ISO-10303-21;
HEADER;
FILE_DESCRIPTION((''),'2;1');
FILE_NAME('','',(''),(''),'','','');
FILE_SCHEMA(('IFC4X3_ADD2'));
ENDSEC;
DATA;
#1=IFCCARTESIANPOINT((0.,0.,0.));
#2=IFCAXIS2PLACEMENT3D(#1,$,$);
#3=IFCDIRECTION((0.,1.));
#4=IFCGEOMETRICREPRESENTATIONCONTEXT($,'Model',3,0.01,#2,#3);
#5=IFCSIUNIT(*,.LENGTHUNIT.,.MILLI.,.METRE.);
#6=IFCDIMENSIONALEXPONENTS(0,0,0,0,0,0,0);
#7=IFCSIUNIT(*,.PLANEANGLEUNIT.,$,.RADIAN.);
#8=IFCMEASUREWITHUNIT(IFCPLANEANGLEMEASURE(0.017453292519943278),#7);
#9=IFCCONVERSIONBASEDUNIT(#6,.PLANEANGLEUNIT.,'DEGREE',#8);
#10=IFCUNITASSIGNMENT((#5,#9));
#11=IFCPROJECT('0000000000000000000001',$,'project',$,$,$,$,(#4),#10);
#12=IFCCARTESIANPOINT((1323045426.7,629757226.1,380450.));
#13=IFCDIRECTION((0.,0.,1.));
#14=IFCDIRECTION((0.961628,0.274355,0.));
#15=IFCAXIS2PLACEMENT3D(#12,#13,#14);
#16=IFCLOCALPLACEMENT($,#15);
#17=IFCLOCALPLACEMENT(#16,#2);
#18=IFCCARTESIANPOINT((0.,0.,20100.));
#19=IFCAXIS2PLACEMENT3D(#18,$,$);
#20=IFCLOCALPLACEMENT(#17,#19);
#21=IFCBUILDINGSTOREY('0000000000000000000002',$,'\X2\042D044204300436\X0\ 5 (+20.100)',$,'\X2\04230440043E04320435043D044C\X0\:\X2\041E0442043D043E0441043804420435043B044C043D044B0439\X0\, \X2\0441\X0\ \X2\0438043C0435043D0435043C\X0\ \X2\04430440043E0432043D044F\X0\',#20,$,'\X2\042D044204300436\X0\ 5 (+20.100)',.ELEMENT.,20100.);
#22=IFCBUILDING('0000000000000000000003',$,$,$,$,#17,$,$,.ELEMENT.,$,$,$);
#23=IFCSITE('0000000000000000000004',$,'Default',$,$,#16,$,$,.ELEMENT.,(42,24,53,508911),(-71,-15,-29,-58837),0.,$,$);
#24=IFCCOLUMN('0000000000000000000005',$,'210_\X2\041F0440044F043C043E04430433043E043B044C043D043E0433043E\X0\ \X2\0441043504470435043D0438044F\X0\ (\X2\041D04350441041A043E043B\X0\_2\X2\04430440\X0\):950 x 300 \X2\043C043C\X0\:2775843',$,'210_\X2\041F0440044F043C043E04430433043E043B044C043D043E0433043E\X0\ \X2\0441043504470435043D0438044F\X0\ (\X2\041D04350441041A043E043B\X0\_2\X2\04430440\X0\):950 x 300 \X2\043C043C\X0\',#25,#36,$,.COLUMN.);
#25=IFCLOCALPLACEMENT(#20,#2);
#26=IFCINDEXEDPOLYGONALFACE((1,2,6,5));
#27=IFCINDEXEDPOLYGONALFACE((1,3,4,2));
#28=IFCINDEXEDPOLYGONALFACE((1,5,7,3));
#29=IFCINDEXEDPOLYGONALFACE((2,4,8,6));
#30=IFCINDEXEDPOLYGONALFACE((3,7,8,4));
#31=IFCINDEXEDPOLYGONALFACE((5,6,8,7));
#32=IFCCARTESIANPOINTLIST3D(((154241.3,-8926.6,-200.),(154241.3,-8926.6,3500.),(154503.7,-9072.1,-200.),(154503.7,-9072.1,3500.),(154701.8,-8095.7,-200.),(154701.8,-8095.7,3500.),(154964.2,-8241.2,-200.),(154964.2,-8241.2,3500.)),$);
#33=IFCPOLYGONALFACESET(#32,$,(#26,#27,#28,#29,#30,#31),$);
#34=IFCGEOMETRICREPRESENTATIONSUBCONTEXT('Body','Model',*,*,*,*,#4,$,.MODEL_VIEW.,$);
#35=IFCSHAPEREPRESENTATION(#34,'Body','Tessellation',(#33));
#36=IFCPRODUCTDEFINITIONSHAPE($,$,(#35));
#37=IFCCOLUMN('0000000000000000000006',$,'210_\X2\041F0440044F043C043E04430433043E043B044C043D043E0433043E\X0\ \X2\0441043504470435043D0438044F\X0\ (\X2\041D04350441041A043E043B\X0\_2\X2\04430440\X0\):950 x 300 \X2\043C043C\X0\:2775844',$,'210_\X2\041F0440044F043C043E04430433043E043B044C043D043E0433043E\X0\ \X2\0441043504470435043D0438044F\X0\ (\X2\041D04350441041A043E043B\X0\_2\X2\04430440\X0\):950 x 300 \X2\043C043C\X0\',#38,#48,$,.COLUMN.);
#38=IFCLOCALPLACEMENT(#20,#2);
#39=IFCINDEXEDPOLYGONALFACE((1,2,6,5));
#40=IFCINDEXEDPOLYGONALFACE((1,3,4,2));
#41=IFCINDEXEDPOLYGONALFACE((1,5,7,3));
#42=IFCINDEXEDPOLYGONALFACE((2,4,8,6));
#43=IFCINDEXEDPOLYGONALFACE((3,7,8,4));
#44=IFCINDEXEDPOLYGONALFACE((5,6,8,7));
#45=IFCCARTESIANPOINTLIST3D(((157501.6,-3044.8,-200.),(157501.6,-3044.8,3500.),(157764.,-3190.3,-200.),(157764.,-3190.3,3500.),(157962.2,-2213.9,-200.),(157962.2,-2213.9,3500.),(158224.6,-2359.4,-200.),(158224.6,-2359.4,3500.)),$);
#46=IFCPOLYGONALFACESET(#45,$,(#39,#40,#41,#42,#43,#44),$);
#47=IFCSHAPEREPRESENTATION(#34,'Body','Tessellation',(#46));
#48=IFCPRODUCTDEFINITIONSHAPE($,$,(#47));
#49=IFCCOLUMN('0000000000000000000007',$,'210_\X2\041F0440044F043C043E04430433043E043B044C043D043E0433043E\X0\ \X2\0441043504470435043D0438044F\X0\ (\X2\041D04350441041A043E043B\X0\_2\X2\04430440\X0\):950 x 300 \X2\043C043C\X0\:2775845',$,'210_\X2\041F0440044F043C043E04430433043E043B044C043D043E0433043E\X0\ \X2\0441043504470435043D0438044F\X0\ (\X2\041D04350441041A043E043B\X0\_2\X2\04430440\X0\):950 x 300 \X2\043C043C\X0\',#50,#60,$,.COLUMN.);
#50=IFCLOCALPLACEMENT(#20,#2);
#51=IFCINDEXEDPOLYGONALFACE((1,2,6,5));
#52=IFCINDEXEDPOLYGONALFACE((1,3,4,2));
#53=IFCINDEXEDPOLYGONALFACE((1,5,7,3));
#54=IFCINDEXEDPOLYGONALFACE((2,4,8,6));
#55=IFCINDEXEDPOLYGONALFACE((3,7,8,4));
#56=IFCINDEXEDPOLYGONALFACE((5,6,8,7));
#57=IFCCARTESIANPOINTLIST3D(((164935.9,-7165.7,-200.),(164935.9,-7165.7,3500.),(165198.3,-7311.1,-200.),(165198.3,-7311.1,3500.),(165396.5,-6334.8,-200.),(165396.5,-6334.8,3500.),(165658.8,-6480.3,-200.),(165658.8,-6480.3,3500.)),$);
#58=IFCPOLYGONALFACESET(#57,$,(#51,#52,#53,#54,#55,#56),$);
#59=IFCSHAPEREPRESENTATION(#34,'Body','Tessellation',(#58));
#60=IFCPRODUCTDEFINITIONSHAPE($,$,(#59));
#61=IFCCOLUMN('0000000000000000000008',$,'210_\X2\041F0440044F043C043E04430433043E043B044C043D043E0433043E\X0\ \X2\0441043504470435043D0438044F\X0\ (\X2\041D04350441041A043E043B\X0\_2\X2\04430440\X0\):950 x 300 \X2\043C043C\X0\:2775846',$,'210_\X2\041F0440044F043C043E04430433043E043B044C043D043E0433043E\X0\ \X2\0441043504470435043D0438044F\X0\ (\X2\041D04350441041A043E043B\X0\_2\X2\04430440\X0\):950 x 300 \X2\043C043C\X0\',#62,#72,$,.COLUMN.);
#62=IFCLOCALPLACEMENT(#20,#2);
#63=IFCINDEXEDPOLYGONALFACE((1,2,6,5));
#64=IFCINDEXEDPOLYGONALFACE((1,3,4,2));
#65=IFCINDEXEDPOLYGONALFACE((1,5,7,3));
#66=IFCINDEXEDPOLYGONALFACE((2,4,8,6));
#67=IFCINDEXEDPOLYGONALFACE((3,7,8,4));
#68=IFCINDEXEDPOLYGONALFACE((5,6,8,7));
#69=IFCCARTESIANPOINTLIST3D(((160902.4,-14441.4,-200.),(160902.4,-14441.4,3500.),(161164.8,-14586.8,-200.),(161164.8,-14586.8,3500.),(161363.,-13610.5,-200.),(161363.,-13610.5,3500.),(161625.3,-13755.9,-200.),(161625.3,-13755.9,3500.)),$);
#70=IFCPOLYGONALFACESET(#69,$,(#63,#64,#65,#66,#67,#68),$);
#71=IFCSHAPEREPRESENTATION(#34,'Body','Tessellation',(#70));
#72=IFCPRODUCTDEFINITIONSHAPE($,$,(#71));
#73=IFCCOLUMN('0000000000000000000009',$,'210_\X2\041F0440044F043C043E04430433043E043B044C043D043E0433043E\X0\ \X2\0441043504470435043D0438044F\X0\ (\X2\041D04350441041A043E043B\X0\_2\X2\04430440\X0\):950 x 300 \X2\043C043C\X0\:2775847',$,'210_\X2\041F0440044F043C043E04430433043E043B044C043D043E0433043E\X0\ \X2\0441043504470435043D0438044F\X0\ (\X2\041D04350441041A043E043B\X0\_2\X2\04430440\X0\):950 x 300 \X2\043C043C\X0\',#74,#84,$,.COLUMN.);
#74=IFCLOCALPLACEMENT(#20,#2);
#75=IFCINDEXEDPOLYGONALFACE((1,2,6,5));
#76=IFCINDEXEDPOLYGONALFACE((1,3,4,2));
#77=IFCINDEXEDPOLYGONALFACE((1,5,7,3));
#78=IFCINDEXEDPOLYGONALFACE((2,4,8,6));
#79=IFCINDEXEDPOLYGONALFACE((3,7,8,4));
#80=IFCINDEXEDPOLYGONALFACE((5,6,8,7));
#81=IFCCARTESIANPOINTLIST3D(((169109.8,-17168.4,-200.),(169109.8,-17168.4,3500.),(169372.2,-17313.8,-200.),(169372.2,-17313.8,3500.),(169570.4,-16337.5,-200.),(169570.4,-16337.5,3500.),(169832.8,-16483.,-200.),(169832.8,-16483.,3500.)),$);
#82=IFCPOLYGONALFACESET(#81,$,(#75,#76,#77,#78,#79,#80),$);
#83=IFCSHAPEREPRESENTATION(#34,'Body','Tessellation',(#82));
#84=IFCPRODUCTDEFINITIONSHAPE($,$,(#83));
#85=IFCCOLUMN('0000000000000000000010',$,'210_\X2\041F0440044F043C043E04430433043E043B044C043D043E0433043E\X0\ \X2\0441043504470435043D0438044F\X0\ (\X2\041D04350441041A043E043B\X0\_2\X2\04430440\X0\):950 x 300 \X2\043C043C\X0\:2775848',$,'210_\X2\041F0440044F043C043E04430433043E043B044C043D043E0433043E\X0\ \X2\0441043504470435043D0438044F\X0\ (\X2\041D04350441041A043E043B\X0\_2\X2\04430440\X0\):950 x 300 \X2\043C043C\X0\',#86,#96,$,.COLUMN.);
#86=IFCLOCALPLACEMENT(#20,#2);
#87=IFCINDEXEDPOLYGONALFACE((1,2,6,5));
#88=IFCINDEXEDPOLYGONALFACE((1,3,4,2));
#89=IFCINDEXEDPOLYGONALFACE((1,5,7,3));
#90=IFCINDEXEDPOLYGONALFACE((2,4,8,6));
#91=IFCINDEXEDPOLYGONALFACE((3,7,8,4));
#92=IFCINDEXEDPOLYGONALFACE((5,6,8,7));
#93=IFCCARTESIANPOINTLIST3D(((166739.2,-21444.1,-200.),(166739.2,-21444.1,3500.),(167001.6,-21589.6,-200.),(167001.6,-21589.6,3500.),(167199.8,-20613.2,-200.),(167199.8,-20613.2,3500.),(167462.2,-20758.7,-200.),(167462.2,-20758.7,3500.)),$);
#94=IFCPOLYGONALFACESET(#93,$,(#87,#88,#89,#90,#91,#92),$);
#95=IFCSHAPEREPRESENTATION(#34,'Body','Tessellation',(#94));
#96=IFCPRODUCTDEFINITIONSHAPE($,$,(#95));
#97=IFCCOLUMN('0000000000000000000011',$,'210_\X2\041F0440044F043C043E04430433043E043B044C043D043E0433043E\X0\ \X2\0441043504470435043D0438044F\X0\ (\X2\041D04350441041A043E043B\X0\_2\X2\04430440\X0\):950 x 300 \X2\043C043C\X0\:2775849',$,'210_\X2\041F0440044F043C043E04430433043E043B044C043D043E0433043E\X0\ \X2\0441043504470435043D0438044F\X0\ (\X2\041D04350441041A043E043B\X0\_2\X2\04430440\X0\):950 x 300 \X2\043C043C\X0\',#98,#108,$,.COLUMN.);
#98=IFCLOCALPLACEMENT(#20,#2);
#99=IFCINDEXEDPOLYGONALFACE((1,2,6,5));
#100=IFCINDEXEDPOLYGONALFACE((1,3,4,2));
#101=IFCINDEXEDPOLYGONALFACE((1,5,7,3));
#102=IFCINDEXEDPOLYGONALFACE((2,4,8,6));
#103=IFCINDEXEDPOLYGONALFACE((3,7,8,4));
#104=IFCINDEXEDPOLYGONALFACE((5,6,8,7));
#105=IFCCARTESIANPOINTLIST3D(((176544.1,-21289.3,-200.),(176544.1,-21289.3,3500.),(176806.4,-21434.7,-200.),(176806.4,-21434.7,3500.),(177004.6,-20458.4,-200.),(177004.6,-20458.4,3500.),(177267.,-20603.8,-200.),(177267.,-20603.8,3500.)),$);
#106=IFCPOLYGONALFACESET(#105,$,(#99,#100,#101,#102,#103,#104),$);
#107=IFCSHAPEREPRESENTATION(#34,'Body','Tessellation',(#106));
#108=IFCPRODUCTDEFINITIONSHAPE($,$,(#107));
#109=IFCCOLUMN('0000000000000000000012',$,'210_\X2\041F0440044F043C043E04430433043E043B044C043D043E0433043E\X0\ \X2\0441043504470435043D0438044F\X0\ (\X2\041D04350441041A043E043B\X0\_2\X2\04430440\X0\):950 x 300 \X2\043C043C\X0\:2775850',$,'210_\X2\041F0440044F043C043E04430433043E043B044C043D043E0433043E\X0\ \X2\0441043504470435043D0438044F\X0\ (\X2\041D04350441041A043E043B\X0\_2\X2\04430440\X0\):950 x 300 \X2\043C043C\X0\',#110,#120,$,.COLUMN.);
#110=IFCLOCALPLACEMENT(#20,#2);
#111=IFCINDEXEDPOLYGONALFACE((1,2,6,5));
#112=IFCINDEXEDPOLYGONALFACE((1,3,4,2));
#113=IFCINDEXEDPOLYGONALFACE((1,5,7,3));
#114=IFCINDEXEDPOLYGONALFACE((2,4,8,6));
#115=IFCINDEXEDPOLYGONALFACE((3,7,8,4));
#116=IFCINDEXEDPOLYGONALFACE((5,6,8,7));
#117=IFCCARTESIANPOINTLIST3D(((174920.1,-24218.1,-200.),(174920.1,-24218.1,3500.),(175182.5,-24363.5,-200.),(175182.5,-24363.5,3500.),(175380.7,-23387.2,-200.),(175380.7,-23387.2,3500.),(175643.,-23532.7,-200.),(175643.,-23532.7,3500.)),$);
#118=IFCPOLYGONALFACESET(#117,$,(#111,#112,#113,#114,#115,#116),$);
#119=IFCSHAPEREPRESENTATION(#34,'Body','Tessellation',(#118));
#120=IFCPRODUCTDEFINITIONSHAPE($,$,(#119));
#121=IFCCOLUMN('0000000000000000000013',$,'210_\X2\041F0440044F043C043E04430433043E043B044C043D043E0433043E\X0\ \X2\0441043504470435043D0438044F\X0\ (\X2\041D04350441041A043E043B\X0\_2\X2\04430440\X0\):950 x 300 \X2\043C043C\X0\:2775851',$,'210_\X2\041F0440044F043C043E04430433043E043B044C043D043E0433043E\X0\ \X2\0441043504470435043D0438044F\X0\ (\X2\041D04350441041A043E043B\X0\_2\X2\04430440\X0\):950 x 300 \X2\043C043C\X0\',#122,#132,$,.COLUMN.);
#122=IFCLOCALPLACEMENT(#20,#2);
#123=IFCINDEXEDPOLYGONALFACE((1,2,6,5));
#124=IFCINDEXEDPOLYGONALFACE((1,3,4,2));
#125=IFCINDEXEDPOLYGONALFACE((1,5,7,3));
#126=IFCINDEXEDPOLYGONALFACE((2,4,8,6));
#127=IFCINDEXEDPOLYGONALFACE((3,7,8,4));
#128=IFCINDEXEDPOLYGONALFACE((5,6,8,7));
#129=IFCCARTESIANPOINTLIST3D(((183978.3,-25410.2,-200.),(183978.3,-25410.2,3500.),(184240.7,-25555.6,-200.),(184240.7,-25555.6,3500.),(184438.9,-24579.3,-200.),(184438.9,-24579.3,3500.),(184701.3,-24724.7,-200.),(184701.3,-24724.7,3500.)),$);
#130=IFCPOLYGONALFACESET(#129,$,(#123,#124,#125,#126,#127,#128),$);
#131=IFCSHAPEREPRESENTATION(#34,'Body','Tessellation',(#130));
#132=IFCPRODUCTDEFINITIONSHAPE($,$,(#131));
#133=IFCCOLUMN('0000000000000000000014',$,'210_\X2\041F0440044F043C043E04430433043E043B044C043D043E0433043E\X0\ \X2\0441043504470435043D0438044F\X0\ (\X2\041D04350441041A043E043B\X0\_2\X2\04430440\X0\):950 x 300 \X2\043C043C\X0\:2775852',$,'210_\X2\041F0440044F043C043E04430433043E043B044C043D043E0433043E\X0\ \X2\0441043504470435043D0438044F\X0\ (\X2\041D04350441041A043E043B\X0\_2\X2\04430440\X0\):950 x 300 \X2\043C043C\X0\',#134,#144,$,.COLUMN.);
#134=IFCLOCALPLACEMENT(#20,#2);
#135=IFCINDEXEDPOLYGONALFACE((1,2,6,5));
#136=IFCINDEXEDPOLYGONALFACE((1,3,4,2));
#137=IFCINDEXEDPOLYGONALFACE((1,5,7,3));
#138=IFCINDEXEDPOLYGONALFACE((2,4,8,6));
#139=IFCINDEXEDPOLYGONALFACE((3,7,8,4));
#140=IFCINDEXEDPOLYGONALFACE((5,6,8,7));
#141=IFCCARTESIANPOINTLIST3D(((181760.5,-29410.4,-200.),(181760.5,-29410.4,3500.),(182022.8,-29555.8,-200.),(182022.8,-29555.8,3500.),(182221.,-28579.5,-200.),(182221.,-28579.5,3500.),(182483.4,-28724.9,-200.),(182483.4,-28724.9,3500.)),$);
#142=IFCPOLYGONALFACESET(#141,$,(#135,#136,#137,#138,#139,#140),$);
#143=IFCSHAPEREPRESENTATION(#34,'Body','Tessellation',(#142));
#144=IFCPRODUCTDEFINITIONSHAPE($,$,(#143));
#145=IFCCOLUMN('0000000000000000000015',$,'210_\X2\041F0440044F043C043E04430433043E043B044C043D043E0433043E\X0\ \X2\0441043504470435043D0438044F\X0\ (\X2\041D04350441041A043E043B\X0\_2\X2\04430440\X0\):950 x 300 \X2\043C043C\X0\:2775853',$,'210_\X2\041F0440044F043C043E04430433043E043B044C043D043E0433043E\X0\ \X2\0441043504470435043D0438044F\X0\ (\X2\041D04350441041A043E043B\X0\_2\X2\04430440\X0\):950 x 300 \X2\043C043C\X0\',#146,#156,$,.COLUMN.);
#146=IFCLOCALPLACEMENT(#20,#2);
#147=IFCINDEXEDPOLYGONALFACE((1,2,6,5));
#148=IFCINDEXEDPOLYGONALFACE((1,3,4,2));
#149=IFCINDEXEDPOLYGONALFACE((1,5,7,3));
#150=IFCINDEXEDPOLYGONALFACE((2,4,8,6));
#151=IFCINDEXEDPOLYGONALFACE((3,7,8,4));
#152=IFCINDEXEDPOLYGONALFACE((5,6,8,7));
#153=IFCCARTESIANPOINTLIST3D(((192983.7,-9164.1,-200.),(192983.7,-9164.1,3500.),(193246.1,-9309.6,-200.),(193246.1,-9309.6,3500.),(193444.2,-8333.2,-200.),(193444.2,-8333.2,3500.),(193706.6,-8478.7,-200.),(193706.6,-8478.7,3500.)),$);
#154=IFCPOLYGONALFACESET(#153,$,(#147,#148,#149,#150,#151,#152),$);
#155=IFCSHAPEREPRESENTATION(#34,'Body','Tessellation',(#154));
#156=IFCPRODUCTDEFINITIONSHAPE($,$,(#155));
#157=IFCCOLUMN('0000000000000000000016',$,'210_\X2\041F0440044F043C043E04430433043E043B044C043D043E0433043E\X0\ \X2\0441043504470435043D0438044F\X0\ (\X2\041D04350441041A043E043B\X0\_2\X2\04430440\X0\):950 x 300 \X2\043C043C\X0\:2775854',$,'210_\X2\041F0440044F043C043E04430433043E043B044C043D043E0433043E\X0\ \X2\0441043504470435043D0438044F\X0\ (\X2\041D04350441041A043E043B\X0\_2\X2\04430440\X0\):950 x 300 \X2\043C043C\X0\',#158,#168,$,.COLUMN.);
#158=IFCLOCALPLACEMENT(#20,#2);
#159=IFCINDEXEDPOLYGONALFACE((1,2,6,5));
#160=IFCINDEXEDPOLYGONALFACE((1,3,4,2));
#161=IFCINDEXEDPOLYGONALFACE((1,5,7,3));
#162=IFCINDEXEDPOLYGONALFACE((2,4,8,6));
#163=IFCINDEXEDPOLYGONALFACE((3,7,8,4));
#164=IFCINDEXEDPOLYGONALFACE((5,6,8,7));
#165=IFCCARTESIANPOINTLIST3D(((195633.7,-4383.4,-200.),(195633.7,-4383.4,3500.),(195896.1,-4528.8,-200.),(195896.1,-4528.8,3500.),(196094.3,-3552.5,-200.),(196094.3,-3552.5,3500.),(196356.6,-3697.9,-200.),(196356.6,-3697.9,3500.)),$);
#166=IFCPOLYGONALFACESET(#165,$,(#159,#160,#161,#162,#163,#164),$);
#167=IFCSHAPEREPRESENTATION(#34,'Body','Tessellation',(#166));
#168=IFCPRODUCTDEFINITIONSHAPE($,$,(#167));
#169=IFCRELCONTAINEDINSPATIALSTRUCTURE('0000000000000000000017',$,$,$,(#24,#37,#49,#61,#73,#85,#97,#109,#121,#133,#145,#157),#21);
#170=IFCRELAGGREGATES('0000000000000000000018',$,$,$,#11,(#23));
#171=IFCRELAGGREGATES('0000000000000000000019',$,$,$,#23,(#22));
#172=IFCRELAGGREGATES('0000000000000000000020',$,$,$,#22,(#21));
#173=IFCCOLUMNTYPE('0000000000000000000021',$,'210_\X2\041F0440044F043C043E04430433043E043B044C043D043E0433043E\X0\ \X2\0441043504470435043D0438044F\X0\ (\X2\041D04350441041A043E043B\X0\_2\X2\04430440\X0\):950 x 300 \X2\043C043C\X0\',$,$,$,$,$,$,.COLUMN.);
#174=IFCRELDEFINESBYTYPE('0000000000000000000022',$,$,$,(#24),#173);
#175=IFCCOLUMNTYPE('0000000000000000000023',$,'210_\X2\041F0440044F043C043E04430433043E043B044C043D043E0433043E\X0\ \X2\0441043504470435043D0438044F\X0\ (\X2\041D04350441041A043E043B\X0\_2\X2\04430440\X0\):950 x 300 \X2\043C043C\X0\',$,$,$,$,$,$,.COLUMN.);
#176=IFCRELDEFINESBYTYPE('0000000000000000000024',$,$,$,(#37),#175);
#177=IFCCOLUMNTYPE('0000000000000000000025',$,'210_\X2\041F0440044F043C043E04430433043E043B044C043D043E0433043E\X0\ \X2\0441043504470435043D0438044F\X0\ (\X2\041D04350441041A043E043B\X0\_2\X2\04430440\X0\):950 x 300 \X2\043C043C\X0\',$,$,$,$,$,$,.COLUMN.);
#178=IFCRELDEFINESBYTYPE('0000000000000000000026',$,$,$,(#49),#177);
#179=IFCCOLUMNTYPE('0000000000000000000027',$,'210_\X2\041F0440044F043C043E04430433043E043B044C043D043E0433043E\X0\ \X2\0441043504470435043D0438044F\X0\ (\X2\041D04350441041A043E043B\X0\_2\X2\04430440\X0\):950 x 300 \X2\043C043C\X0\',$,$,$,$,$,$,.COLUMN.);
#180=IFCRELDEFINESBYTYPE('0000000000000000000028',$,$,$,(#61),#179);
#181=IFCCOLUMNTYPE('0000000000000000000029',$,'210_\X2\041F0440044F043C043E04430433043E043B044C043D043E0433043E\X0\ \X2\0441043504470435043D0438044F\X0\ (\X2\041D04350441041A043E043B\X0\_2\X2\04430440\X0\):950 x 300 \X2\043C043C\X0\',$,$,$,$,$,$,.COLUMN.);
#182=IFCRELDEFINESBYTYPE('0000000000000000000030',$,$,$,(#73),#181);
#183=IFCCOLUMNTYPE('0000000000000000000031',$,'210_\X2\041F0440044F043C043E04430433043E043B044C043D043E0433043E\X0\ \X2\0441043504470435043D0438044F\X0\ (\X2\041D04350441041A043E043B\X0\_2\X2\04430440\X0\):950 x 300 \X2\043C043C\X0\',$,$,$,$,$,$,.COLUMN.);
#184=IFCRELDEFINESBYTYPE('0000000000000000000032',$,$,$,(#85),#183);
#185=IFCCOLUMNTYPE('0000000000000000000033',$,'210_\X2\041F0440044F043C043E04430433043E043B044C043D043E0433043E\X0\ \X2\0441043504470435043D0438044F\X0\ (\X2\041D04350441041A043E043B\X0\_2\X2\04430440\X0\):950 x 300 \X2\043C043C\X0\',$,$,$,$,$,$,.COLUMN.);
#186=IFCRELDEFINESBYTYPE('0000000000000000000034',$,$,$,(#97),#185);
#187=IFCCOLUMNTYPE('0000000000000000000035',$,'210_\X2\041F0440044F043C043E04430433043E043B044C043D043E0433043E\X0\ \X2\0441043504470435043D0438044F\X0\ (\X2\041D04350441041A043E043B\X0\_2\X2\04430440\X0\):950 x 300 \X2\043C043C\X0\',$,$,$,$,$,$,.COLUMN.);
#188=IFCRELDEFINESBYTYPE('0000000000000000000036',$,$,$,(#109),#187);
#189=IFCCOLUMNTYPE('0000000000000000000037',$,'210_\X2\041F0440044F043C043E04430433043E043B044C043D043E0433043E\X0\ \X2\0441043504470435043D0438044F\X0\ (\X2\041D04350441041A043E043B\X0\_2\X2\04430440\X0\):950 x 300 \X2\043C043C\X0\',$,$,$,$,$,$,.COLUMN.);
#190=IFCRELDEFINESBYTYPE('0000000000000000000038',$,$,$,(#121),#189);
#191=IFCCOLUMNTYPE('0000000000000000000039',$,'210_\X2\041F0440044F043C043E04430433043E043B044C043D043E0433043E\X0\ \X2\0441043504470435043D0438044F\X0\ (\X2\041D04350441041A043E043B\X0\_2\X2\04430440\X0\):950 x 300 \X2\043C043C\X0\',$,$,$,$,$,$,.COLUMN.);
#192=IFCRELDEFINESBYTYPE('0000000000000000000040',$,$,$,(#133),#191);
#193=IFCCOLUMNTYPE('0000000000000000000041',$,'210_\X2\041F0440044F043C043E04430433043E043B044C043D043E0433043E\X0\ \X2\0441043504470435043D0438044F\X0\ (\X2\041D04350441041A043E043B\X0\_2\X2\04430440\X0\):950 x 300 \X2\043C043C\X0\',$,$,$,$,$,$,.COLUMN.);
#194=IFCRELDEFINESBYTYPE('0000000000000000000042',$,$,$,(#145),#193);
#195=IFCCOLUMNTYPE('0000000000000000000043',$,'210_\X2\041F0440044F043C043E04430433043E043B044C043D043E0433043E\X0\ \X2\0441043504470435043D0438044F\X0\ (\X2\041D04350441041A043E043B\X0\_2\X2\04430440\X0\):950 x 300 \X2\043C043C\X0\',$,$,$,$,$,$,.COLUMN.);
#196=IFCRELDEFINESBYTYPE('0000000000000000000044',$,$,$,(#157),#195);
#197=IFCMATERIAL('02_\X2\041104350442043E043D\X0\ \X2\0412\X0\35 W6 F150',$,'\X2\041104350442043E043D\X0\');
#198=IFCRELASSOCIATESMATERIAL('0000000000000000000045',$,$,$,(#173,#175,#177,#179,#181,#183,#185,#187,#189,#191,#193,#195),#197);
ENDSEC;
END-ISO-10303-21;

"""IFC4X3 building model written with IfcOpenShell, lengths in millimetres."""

from ifc_helpers import new_model, entity, si_unit, converted_unit, direction, frame, frame_2d, origin, origin_2d_with_axis, place, context, subcontext, project, spatial, rectangle, extrude, source, transform, mapped, material, material_profile, profile_set, type_object, type_shapes, element, save


model = new_model("IFC4X3")

# Units and contexts
model_context = context("Model", 3, precision=0.01, world=origin(), true_north=direction((0.0, 1.0)))
body_context = subcontext(model_context, "Body", "Model", "MODEL_VIEW")
ifc_project = project(units=[si_unit("LENGTHUNIT", "METRE", prefix="MILLI"), converted_unit("PLANEANGLEUNIT", "DEGREE", entity("IfcPlaneAngleMeasure", 0.017453292519943278), si_unit("PLANEANGLEUNIT", "RADIAN"), dimensions=[0, 0, 0, 0, 0, 0, 0])], contexts=[model_context])

# Site, building, storey
site_placement = place(None, frame((1323045426.7, 629757226.1, 380450.0), z_axis=(0.0, 0.0, 1.0), x_axis=(0.961628, 0.274355, 0.0)))
site = spatial("IfcSite", under=ifc_project, at=site_placement, Name="Default", CompositionType="ELEMENT", RefLatitude=(42, 24, 53, 508911), RefLongitude=(-71, -15, -29, -58837), RefElevation=0.0)
building_placement = place(site_placement, origin())
building = spatial("IfcBuilding", under=site, at=building_placement, CompositionType="ELEMENT")
storey_placement = place(building_placement, frame((0.0, 0.0, 20100.0)))
storey = spatial("IfcBuildingStorey", under=building, at=storey_placement, Name="Этаж 5 (+20.100)", ObjectType="Уровень:Относительный, с именем уровня", LongName="Этаж 5 (+20.100)", CompositionType="ELEMENT", Elevation=20100.0)

# Columns
ifc_material_1 = material(Name="02_Бетон В35 W6 F150", Category="Бетон")
ifc_material_profile_1 = material_profile(ifc_material_1, rectangle(XDim=300.0, YDim=950.0, at=frame_2d((0.0, 0.0), x_axis=(1.0, 0.0))), Name="950 x 300 мм")
ifc_profile_set_1 = profile_set([ifc_material_profile_1], Name="950 x 300 мм")
column_type_1 = type_object("IfcColumnType", Name="210_Прямоугольного сечения (НесКол_2ур):950 x 300 мм", PredefinedType="COLUMN", material=ifc_profile_set_1)
shared_shape_1 = source(origin(), body_context, "Body", "SweptSolid", [
    extrude(rectangle(XDim=300.0, YDim=950.0, at=frame_2d((0.0, 0.0), x_axis=(1.0, 0.0))), frame((154602.7, -8583.9, 19900.0), z_axis=(0.0, 0.0, 1.0), x_axis=(-0.87462, 0.48481, 0.0)), (0.0, 0.0, 1.0), 3700.0),
])
type_shapes(column_type_1, [shared_shape_1])
column_1_placement = place(storey_placement, frame((0.0, 0.0, -20100.0)))
element("IfcColumn", 1, at=column_1_placement, inside=storey, type_object=column_type_1, Name="210_Прямоугольного сечения (НесКол_2ур):950 x 300 мм:2775843", ObjectType="210_Прямоугольного сечения (НесКол_2ур):950 x 300 мм", PredefinedType="COLUMN", context=body_context, shape_type="MappedRepresentation", body=[
    mapped(shared_shape_1, transform((0.0, 0.0, 0.0), scale=1.0)),
])
column_type_2 = type_object("IfcColumnType", Name="210_Прямоугольного сечения (НесКол_2ур):950 x 300 мм", PredefinedType="COLUMN", material=ifc_profile_set_1)
shared_shape_2 = source(origin(), body_context, "Body", "SweptSolid", [
    extrude(rectangle(XDim=300.0, YDim=950.0, at=frame_2d((0.0, 0.0), x_axis=(1.0, 0.0))), frame((157863.1, -2702.1, 19900.0), z_axis=(0.0, 0.0, 1.0), x_axis=(-0.87462, 0.48481, 0.0)), (0.0, 0.0, 1.0), 3700.0),
])
type_shapes(column_type_2, [shared_shape_2])
column_2_placement = place(storey_placement, frame((0.0, 0.0, -20100.0)))
element("IfcColumn", 2, at=column_2_placement, inside=storey, type_object=column_type_2, Name="210_Прямоугольного сечения (НесКол_2ур):950 x 300 мм:2775844", ObjectType="210_Прямоугольного сечения (НесКол_2ур):950 x 300 мм", PredefinedType="COLUMN", context=body_context, shape_type="MappedRepresentation", body=[
    mapped(shared_shape_2, transform((0.0, 0.0, 0.0), scale=1.0)),
])
column_type_3 = type_object("IfcColumnType", Name="210_Прямоугольного сечения (НесКол_2ур):950 x 300 мм", PredefinedType="COLUMN", material=ifc_profile_set_1)
shared_shape_3 = source(origin(), body_context, "Body", "SweptSolid", [
    extrude(rectangle(XDim=300.0, YDim=950.0, at=frame_2d((0.0, 0.0), x_axis=(1.0, 0.0))), frame((165297.4, -6823.0, 19900.0), z_axis=(0.0, 0.0, 1.0), x_axis=(-0.87462, 0.48481, 0.0)), (0.0, 0.0, 1.0), 3700.0),
])
type_shapes(column_type_3, [shared_shape_3])
column_3_placement = place(storey_placement, frame((0.0, 0.0, -20100.0)))
element("IfcColumn", 3, at=column_3_placement, inside=storey, type_object=column_type_3, Name="210_Прямоугольного сечения (НесКол_2ур):950 x 300 мм:2775845", ObjectType="210_Прямоугольного сечения (НесКол_2ур):950 x 300 мм", PredefinedType="COLUMN", context=body_context, shape_type="MappedRepresentation", body=[
    mapped(shared_shape_3, transform((0.0, 0.0, 0.0), scale=1.0)),
])
column_type_4 = type_object("IfcColumnType", Name="210_Прямоугольного сечения (НесКол_2ур):950 x 300 мм", PredefinedType="COLUMN", material=ifc_profile_set_1)
shared_shape_4 = source(origin(), body_context, "Body", "SweptSolid", [
    extrude(rectangle(XDim=300.0, YDim=950.0, at=frame_2d((0.0, 0.0), x_axis=(1.0, 0.0))), frame((161263.9, -14098.7, 19900.0), z_axis=(0.0, 0.0, 1.0), x_axis=(-0.87462, 0.48481, 0.0)), (0.0, 0.0, 1.0), 3700.0),
])
type_shapes(column_type_4, [shared_shape_4])
column_4_placement = place(storey_placement, frame((0.0, 0.0, -20100.0)))
element("IfcColumn", 4, at=column_4_placement, inside=storey, type_object=column_type_4, Name="210_Прямоугольного сечения (НесКол_2ур):950 x 300 мм:2775846", ObjectType="210_Прямоугольного сечения (НесКол_2ур):950 x 300 мм", PredefinedType="COLUMN", context=body_context, shape_type="MappedRepresentation", body=[
    mapped(shared_shape_4, transform((0.0, 0.0, 0.0), scale=1.0)),
])
column_type_5 = type_object("IfcColumnType", Name="210_Прямоугольного сечения (НесКол_2ур):950 x 300 мм", PredefinedType="COLUMN", material=ifc_profile_set_1)
shared_shape_5 = source(origin(), body_context, "Body", "SweptSolid", [
    extrude(rectangle(XDim=300.0, YDim=950.0, at=origin_2d_with_axis()), frame((169471.3, -16825.7, 19900.0), z_axis=(0.0, 0.0, 1.0), x_axis=(-0.87462, 0.48481, 0.0)), (0.0, 0.0, 1.0), 3700.0),
])
type_shapes(column_type_5, [shared_shape_5])
column_5_placement = place(storey_placement, frame((0.0, 0.0, -20100.0)))
element("IfcColumn", 5, at=column_5_placement, inside=storey, type_object=column_type_5, Name="210_Прямоугольного сечения (НесКол_2ур):950 x 300 мм:2775847", ObjectType="210_Прямоугольного сечения (НесКол_2ур):950 x 300 мм", PredefinedType="COLUMN", context=body_context, shape_type="MappedRepresentation", body=[
    mapped(shared_shape_5, transform((0.0, 0.0, 0.0), scale=1.0)),
])
column_type_6 = type_object("IfcColumnType", Name="210_Прямоугольного сечения (НесКол_2ур):950 x 300 мм", PredefinedType="COLUMN", material=ifc_profile_set_1)
shared_shape_6 = source(origin(), body_context, "Body", "SweptSolid", [
    extrude(rectangle(XDim=300.0, YDim=950.0, at=origin_2d_with_axis()), frame((167100.7, -21101.4, 19900.0), z_axis=(0.0, 0.0, 1.0), x_axis=(-0.87462, 0.48481, 0.0)), (0.0, 0.0, 1.0), 3700.0),
])
type_shapes(column_type_6, [shared_shape_6])
column_6_placement = place(storey_placement, frame((0.0, 0.0, -20100.0)))
element("IfcColumn", 6, at=column_6_placement, inside=storey, type_object=column_type_6, Name="210_Прямоугольного сечения (НесКол_2ур):950 x 300 мм:2775848", ObjectType="210_Прямоугольного сечения (НесКол_2ур):950 x 300 мм", PredefinedType="COLUMN", context=body_context, shape_type="MappedRepresentation", body=[
    mapped(shared_shape_6, transform((0.0, 0.0, 0.0), scale=1.0)),
])
column_type_7 = type_object("IfcColumnType", Name="210_Прямоугольного сечения (НесКол_2ур):950 x 300 мм", PredefinedType="COLUMN", material=ifc_profile_set_1)
shared_shape_7 = source(origin(), body_context, "Body", "SweptSolid", [
    extrude(rectangle(XDim=300.0, YDim=950.0, at=origin_2d_with_axis()), frame((176905.5, -20946.6, 19900.0), z_axis=(0.0, 0.0, 1.0), x_axis=(-0.87462, 0.48481, 0.0)), (0.0, 0.0, 1.0), 3700.0),
])
type_shapes(column_type_7, [shared_shape_7])
column_7_placement = place(storey_placement, frame((0.0, 0.0, -20100.0)))
element("IfcColumn", 7, at=column_7_placement, inside=storey, type_object=column_type_7, Name="210_Прямоугольного сечения (НесКол_2ур):950 x 300 мм:2775849", ObjectType="210_Прямоугольного сечения (НесКол_2ур):950 x 300 мм", PredefinedType="COLUMN", context=body_context, shape_type="MappedRepresentation", body=[
    mapped(shared_shape_7, transform((0.0, 0.0, 0.0), scale=1.0)),
])
column_type_8 = type_object("IfcColumnType", Name="210_Прямоугольного сечения (НесКол_2ур):950 x 300 мм", PredefinedType="COLUMN", material=ifc_profile_set_1)
shared_shape_8 = source(origin(), body_context, "Body", "SweptSolid", [
    extrude(rectangle(XDim=300.0, YDim=950.0, at=frame_2d((0.0, 0.0), x_axis=(1.0, 0.0))), frame((175281.6, -23875.4, 19900.0), z_axis=(0.0, 0.0, 1.0), x_axis=(-0.87462, 0.48481, 0.0)), (0.0, 0.0, 1.0), 3700.0),
])
type_shapes(column_type_8, [shared_shape_8])
column_8_placement = place(storey_placement, frame((0.0, 0.0, -20100.0)))
element("IfcColumn", 8, at=column_8_placement, inside=storey, type_object=column_type_8, Name="210_Прямоугольного сечения (НесКол_2ур):950 x 300 мм:2775850", ObjectType="210_Прямоугольного сечения (НесКол_2ур):950 x 300 мм", PredefinedType="COLUMN", context=body_context, shape_type="MappedRepresentation", body=[
    mapped(shared_shape_8, transform((0.0, 0.0, 0.0), scale=1.0)),
])
column_type_9 = type_object("IfcColumnType", Name="210_Прямоугольного сечения (НесКол_2ур):950 x 300 мм", PredefinedType="COLUMN", material=ifc_profile_set_1)
shared_shape_9 = source(origin(), body_context, "Body", "SweptSolid", [
    extrude(rectangle(XDim=300.0, YDim=950.0, at=frame_2d((0.0, 0.0), x_axis=(1.0, 0.0))), frame((184339.8, -25067.5, 19900.0), z_axis=(0.0, 0.0, 1.0), x_axis=(-0.87462, 0.48481, 0.0)), (0.0, 0.0, 1.0), 3700.0),
])
type_shapes(column_type_9, [shared_shape_9])
column_9_placement = place(storey_placement, frame((0.0, 0.0, -20100.0)))
element("IfcColumn", 9, at=column_9_placement, inside=storey, type_object=column_type_9, Name="210_Прямоугольного сечения (НесКол_2ур):950 x 300 мм:2775851", ObjectType="210_Прямоугольного сечения (НесКол_2ур):950 x 300 мм", PredefinedType="COLUMN", context=body_context, shape_type="MappedRepresentation", body=[
    mapped(shared_shape_9, transform((0.0, 0.0, 0.0), scale=1.0)),
])
column_type_10 = type_object("IfcColumnType", Name="210_Прямоугольного сечения (НесКол_2ур):950 x 300 мм", PredefinedType="COLUMN", material=ifc_profile_set_1)
shared_shape_10 = source(origin(), body_context, "Body", "SweptSolid", [
    extrude(rectangle(XDim=300.0, YDim=950.0, at=origin_2d_with_axis()), frame((182121.9, -29067.7, 19900.0), z_axis=(0.0, 0.0, 1.0), x_axis=(-0.87462, 0.48481, 0.0)), (0.0, 0.0, 1.0), 3700.0),
])
type_shapes(column_type_10, [shared_shape_10])
column_10_placement = place(storey_placement, frame((0.0, 0.0, -20100.0)))
element("IfcColumn", 10, at=column_10_placement, inside=storey, type_object=column_type_10, Name="210_Прямоугольного сечения (НесКол_2ур):950 x 300 мм:2775852", ObjectType="210_Прямоугольного сечения (НесКол_2ур):950 x 300 мм", PredefinedType="COLUMN", context=body_context, shape_type="MappedRepresentation", body=[
    mapped(shared_shape_10, transform((0.0, 0.0, 0.0), scale=1.0)),
])
column_type_11 = type_object("IfcColumnType", Name="210_Прямоугольного сечения (НесКол_2ур):950 x 300 мм", PredefinedType="COLUMN", material=ifc_profile_set_1)
shared_shape_11 = source(origin(), body_context, "Body", "SweptSolid", [
    extrude(rectangle(XDim=300.0, YDim=950.0, at=frame_2d((0.0, 0.0), x_axis=(1.0, 0.0))), frame((193345.2, -8821.4, 19900.0), z_axis=(0.0, 0.0, 1.0), x_axis=(-0.87462, 0.48481, 0.0)), (0.0, 0.0, 1.0), 3700.0),
])
type_shapes(column_type_11, [shared_shape_11])
column_11_placement = place(storey_placement, frame((0.0, 0.0, -20100.0)))
element("IfcColumn", 11, at=column_11_placement, inside=storey, type_object=column_type_11, Name="210_Прямоугольного сечения (НесКол_2ур):950 x 300 мм:2775853", ObjectType="210_Прямоугольного сечения (НесКол_2ур):950 x 300 мм", PredefinedType="COLUMN", context=body_context, shape_type="MappedRepresentation", body=[
    mapped(shared_shape_11, transform((0.0, 0.0, 0.0), scale=1.0)),
])
column_type_12 = type_object("IfcColumnType", Name="210_Прямоугольного сечения (НесКол_2ур):950 x 300 мм", PredefinedType="COLUMN", material=ifc_profile_set_1)
shared_shape_12 = source(origin(), body_context, "Body", "SweptSolid", [
    extrude(rectangle(XDim=300.0, YDim=950.0, at=frame_2d((0.0, 0.0), x_axis=(1.0, 0.0))), frame((195995.2, -4040.7, 19900.0), z_axis=(0.0, 0.0, 1.0), x_axis=(-0.87462, 0.48481, 0.0)), (0.0, 0.0, 1.0), 3700.0),
])
type_shapes(column_type_12, [shared_shape_12])
column_12_placement = place(storey_placement, frame((0.0, 0.0, -20100.0)))
element("IfcColumn", 12, at=column_12_placement, inside=storey, type_object=column_type_12, Name="210_Прямоугольного сечения (НесКол_2ур):950 x 300 мм:2775854", ObjectType="210_Прямоугольного сечения (НесКол_2ур):950 x 300 мм", PredefinedType="COLUMN", context=body_context, shape_type="MappedRepresentation", body=[
    mapped(shared_shape_12, transform((0.0, 0.0, 0.0), scale=1.0)),
])

save(model, "model.ifc")
